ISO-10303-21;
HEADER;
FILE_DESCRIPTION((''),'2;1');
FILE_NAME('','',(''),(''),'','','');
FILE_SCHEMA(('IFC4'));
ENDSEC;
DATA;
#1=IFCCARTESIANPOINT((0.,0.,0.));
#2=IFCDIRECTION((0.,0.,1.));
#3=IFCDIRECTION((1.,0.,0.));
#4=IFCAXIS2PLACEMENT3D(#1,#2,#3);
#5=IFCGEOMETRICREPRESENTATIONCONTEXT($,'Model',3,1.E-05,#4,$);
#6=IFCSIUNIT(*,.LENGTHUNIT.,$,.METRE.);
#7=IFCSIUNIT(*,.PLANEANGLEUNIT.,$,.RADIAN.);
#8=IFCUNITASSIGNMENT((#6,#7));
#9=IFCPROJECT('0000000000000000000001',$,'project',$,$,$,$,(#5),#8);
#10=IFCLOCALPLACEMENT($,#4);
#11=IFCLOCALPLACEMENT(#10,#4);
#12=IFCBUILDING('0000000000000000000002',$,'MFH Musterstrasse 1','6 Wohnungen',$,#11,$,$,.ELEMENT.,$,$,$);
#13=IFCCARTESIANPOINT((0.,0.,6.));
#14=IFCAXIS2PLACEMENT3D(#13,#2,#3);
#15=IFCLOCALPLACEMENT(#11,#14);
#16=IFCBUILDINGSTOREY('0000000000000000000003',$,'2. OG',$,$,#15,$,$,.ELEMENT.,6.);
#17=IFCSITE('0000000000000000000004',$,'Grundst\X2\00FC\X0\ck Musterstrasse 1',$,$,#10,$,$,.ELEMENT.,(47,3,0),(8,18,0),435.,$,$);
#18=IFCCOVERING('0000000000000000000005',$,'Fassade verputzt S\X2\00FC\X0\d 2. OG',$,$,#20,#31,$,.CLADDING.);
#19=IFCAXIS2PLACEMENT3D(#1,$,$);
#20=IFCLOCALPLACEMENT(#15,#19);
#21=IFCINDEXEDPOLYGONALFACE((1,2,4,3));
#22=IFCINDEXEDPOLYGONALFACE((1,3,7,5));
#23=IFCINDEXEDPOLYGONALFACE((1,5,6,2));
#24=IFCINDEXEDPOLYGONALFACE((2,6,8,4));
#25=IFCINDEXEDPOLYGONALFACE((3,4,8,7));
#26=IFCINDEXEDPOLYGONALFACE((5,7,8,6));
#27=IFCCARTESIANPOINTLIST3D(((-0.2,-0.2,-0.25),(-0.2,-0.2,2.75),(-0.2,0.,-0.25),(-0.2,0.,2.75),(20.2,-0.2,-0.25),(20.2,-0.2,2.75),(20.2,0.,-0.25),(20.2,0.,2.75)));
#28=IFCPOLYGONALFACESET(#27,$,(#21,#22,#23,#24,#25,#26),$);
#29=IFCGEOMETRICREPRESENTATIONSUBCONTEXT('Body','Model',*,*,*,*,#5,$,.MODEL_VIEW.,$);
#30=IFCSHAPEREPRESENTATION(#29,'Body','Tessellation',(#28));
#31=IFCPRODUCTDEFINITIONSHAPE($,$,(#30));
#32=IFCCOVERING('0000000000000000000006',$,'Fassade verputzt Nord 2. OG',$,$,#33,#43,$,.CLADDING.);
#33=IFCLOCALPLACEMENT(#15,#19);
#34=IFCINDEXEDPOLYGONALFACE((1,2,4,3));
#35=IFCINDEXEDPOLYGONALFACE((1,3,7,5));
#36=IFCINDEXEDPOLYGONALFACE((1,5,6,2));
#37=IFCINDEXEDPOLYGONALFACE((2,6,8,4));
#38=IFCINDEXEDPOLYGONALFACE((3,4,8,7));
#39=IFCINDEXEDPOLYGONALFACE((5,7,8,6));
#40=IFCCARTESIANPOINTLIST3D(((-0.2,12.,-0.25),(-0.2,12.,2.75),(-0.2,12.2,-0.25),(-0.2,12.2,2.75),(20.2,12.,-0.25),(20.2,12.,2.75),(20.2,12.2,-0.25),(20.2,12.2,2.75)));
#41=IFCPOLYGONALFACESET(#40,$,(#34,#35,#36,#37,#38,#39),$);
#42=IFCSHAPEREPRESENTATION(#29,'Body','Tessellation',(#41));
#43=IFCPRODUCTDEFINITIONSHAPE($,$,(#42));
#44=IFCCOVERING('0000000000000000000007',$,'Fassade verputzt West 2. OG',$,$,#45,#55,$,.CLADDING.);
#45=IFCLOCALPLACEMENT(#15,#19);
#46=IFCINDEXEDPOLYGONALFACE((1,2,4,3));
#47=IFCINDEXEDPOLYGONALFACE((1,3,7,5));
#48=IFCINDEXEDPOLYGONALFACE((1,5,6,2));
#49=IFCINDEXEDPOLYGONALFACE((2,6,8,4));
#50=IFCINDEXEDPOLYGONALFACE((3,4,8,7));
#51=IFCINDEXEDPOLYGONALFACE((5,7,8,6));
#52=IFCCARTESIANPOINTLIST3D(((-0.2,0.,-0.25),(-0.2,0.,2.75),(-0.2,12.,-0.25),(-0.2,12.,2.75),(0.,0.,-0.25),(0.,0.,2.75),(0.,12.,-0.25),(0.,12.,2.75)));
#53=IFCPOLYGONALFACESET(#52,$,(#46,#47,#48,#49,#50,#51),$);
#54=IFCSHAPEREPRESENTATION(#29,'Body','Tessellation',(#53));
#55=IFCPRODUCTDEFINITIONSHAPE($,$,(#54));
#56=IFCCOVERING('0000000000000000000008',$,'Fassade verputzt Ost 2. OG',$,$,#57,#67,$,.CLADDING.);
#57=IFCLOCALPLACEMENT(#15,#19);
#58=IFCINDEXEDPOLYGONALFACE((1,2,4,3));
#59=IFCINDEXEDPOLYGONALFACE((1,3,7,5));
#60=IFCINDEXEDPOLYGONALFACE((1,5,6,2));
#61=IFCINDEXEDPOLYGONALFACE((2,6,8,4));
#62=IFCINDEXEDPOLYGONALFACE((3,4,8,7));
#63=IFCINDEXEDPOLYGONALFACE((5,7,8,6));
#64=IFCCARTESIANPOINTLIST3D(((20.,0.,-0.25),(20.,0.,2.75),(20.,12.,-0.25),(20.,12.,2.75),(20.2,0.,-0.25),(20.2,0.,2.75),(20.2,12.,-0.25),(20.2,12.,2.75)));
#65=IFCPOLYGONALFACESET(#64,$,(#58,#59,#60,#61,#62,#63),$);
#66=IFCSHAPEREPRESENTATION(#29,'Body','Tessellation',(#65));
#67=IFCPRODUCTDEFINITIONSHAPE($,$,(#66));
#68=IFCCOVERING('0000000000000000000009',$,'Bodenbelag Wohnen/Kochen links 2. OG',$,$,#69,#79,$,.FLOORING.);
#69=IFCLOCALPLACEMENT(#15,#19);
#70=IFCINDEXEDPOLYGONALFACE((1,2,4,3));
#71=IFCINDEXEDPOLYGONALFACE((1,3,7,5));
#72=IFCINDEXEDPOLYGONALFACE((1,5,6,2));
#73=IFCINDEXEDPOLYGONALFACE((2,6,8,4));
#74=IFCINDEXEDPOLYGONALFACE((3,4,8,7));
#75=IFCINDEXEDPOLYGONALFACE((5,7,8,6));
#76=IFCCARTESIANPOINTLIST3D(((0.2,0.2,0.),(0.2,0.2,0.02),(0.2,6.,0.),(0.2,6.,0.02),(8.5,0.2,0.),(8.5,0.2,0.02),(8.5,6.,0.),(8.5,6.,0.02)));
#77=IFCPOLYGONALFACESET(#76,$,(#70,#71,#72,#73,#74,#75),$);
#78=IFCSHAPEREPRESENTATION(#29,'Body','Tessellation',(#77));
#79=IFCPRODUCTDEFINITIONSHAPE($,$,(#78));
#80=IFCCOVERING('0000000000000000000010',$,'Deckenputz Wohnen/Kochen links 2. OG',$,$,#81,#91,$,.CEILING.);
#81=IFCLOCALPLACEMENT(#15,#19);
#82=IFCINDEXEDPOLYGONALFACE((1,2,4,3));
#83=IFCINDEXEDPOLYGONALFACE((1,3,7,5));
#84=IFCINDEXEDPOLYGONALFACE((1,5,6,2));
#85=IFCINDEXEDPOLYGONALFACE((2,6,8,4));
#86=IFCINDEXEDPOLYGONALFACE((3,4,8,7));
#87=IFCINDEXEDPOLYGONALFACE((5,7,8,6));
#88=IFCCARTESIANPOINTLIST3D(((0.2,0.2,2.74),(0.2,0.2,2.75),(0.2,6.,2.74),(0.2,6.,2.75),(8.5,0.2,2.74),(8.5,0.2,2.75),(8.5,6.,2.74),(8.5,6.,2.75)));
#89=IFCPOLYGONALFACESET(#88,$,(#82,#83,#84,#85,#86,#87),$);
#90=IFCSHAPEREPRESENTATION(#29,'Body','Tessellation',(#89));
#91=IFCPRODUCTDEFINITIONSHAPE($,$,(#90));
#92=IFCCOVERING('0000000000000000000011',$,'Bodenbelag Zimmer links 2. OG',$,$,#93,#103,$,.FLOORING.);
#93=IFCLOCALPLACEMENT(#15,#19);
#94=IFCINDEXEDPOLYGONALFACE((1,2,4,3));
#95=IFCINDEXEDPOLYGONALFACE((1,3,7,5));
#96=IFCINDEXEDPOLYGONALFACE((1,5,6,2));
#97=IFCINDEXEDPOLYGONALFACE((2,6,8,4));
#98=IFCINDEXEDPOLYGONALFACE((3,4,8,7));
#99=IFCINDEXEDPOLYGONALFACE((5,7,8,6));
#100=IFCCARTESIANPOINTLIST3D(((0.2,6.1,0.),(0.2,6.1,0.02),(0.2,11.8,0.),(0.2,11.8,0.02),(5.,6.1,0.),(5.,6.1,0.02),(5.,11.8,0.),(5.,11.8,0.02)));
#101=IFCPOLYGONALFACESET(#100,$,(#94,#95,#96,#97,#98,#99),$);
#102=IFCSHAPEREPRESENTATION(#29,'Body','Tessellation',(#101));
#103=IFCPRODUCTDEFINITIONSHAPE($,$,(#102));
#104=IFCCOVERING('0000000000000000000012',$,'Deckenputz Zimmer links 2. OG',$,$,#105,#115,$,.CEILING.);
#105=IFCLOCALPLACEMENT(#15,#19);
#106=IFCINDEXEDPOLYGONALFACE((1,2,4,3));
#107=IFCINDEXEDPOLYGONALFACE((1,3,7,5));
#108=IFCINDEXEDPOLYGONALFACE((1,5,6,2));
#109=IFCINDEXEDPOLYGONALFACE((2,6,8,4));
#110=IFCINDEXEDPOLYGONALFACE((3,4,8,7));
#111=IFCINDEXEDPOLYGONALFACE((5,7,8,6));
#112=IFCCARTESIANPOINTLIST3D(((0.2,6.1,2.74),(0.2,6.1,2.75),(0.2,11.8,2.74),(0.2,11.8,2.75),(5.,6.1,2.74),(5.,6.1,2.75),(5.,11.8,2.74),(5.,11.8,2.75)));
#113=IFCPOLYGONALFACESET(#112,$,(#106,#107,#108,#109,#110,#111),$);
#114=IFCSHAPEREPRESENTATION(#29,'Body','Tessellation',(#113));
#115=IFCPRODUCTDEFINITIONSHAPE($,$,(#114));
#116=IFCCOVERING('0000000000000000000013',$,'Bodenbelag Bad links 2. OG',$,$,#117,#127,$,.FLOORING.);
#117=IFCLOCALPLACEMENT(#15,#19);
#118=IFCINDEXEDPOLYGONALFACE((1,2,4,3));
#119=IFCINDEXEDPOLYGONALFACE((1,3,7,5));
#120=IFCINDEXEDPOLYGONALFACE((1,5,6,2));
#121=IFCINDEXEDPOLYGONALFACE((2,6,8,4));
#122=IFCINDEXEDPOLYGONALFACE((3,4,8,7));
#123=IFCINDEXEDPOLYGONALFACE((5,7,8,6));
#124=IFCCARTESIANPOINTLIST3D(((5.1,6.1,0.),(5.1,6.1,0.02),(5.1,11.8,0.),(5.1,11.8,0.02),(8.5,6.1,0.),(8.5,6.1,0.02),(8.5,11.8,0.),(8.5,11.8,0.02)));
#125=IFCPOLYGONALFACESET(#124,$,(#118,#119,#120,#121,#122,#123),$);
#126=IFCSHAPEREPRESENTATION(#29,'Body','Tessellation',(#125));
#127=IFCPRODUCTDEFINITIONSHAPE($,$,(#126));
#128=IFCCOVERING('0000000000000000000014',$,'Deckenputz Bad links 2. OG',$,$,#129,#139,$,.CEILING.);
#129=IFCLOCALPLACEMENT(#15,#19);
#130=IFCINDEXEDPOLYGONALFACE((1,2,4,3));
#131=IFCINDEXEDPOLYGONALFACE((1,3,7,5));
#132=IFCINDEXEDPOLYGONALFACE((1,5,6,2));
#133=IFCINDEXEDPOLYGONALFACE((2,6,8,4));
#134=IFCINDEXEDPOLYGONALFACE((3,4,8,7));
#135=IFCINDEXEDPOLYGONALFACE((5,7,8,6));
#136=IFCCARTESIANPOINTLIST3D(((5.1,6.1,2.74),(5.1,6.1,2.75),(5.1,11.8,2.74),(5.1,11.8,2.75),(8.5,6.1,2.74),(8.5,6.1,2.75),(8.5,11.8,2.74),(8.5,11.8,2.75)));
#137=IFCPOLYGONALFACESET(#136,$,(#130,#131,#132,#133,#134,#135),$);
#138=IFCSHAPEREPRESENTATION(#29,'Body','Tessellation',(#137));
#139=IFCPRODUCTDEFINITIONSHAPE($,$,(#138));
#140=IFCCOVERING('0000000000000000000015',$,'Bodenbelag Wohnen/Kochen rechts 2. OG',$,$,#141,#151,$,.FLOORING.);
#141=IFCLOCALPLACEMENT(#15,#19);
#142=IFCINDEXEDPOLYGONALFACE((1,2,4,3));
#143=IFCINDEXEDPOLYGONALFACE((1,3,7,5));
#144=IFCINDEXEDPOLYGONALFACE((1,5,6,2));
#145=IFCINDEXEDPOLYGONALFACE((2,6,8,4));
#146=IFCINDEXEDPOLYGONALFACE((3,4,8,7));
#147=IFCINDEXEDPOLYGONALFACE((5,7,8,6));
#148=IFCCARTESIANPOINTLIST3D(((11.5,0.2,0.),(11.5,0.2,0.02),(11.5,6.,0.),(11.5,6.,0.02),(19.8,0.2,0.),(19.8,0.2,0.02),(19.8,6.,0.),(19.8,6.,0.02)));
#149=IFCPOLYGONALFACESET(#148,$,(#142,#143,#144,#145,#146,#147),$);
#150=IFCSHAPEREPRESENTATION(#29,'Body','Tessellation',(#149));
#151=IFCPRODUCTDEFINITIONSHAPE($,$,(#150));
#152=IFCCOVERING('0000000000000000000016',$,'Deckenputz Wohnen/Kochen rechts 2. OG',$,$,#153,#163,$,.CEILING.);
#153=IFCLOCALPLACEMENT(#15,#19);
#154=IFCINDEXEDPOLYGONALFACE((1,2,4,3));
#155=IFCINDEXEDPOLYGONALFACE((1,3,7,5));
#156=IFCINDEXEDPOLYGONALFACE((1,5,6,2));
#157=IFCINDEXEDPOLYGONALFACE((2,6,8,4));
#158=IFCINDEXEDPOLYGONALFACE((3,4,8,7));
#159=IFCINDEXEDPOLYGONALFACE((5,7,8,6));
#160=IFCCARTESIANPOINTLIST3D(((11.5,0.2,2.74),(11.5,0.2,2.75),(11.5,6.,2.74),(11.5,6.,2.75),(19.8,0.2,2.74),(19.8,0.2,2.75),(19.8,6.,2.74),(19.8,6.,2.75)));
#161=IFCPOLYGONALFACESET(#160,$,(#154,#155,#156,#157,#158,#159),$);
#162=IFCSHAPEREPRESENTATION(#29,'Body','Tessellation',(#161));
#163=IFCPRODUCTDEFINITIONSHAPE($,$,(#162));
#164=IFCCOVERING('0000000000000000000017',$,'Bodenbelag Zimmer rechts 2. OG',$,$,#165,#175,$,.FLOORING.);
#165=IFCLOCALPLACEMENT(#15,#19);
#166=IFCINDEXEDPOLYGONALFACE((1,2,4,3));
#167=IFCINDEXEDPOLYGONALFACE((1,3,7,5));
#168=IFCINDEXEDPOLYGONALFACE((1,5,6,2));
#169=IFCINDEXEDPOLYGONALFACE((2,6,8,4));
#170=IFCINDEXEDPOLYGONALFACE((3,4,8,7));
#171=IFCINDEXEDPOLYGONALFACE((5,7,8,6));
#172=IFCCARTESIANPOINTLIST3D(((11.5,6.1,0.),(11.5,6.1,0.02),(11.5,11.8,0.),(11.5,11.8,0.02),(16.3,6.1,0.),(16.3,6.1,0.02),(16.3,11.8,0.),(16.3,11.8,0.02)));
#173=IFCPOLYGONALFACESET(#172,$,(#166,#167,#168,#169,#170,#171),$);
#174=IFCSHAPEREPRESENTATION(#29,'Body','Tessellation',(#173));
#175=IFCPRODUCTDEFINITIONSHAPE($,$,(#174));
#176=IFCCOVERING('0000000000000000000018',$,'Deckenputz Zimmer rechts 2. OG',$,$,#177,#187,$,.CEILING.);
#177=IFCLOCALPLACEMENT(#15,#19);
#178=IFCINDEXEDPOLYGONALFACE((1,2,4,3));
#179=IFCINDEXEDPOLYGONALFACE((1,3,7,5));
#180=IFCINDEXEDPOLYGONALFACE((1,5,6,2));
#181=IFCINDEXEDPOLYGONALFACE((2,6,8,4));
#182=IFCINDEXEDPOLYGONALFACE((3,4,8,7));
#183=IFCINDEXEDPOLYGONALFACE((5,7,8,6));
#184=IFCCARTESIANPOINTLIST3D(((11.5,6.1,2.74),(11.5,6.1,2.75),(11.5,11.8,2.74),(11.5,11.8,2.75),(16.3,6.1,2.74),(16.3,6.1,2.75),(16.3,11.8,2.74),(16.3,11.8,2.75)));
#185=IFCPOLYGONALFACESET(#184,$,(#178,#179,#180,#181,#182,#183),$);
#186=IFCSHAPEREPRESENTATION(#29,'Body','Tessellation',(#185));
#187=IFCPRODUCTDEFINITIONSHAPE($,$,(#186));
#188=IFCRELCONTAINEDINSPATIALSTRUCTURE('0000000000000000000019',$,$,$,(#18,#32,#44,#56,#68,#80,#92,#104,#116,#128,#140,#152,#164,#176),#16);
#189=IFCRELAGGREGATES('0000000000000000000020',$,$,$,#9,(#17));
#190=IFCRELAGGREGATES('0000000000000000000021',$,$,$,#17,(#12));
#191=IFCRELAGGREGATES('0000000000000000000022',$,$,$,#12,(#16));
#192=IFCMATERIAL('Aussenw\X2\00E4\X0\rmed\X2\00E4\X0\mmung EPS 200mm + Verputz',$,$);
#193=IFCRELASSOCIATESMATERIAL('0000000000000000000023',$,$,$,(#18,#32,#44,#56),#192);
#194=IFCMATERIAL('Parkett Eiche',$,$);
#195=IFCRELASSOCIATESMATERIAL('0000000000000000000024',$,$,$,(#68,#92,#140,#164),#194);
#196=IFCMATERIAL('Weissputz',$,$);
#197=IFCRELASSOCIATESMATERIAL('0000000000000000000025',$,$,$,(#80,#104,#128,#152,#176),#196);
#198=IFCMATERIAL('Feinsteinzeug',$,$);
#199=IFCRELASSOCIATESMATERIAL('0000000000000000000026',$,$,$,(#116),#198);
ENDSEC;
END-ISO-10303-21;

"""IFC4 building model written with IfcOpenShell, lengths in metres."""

from ifc_helpers import new_model, si_unit, frame, frame_2d, origin_with_axes, place, context, subcontext, project, spatial, rectangle, extrude, material, element, save


model = new_model("IFC4")

# Units and contexts
model_context = context("Model", 3, precision=1e-05, world=origin_with_axes())
body_context = subcontext(model_context, "Body", "Model", "MODEL_VIEW")
ifc_project = project(units=[si_unit("LENGTHUNIT", "METRE"), si_unit("PLANEANGLEUNIT", "RADIAN")], contexts=[model_context])

# Site, building, storey
site_placement = place(None, origin_with_axes())
site = spatial("IfcSite", under=ifc_project, at=site_placement, Name="Grundstück Musterstrasse 1", CompositionType="ELEMENT", RefLatitude=(47, 3, 0), RefLongitude=(8, 18, 0), RefElevation=435.0)
building_placement = place(site_placement, origin_with_axes())
building = spatial("IfcBuilding", under=site, at=building_placement, Name="MFH Musterstrasse 1", Description="6 Wohnungen", CompositionType="ELEMENT")
storey_placement = place(building_placement, frame((0.0, 0.0, 6.0), z_axis=(0.0, 0.0, 1.0), x_axis=(1.0, 0.0, 0.0)))
storey = spatial("IfcBuildingStorey", under=building, at=storey_placement, Name="2. OG", CompositionType="ELEMENT", Elevation=6.0)

# Coverings
ifc_material_1 = material(Name="Aussenwärmedämmung EPS 200mm + Verputz")
covering_1_placement = place(storey_placement, origin_with_axes())
element("IfcCovering", 1, at=covering_1_placement, inside=storey, material=ifc_material_1, Name="Fassade verputzt Süd 2. OG", PredefinedType="CLADDING", context=body_context, shape_type="SweptSolid", body=[
    extrude(rectangle(XDim=20.4, YDim=0.2, at=frame_2d((10.2, 0.1), x_axis=(1.0, 0.0))), frame((-0.2, -0.2, -0.25), z_axis=(0.0, 0.0, 1.0), x_axis=(1.0, 0.0, 0.0)), (0.0, 0.0, 1.0), 3.0),
])
covering_2_placement = place(storey_placement, origin_with_axes())
element("IfcCovering", 2, at=covering_2_placement, inside=storey, material=ifc_material_1, Name="Fassade verputzt Nord 2. OG", PredefinedType="CLADDING", context=body_context, shape_type="SweptSolid", body=[
    extrude(rectangle(XDim=20.4, YDim=0.2, at=frame_2d((10.2, 0.1), x_axis=(1.0, 0.0))), frame((-0.2, 12.0, -0.25), z_axis=(0.0, 0.0, 1.0), x_axis=(1.0, 0.0, 0.0)), (0.0, 0.0, 1.0), 3.0),
])
covering_3_placement = place(storey_placement, origin_with_axes())
element("IfcCovering", 3, at=covering_3_placement, inside=storey, material=ifc_material_1, Name="Fassade verputzt West 2. OG", PredefinedType="CLADDING", context=body_context, shape_type="SweptSolid", body=[
    extrude(rectangle(XDim=0.2, YDim=12.0, at=frame_2d((0.1, 6.0), x_axis=(1.0, 0.0))), frame((-0.2, 0.0, -0.25), z_axis=(0.0, 0.0, 1.0), x_axis=(1.0, 0.0, 0.0)), (0.0, 0.0, 1.0), 3.0),
])
covering_4_placement = place(storey_placement, origin_with_axes())
element("IfcCovering", 4, at=covering_4_placement, inside=storey, material=ifc_material_1, Name="Fassade verputzt Ost 2. OG", PredefinedType="CLADDING", context=body_context, shape_type="SweptSolid", body=[
    extrude(rectangle(XDim=0.2, YDim=12.0, at=frame_2d((0.1, 6.0), x_axis=(1.0, 0.0))), frame((20.0, 0.0, -0.25), z_axis=(0.0, 0.0, 1.0), x_axis=(1.0, 0.0, 0.0)), (0.0, 0.0, 1.0), 3.0),
])
ifc_material_2 = material(Name="Parkett Eiche")
covering_5_placement = place(storey_placement, origin_with_axes())
element("IfcCovering", 5, at=covering_5_placement, inside=storey, material=ifc_material_2, Name="Bodenbelag Wohnen/Kochen links 2. OG", PredefinedType="FLOORING", context=body_context, shape_type="SweptSolid", body=[
    extrude(rectangle(XDim=8.3, YDim=5.8, at=frame_2d((4.15, 2.9), x_axis=(1.0, 0.0))), frame((0.2, 0.2, 0.0), z_axis=(0.0, 0.0, 1.0), x_axis=(1.0, 0.0, 0.0)), (0.0, 0.0, 1.0), 0.02),
])
ifc_material_3 = material(Name="Weissputz")
covering_6_placement = place(storey_placement, origin_with_axes())
element("IfcCovering", 6, at=covering_6_placement, inside=storey, material=ifc_material_3, Name="Deckenputz Wohnen/Kochen links 2. OG", PredefinedType="CEILING", context=body_context, shape_type="SweptSolid", body=[
    extrude(rectangle(XDim=8.3, YDim=5.8, at=frame_2d((4.15, 2.9), x_axis=(1.0, 0.0))), frame((0.2, 0.2, 2.74), z_axis=(0.0, 0.0, 1.0), x_axis=(1.0, 0.0, 0.0)), (0.0, 0.0, 1.0), 0.01),
])
covering_7_placement = place(storey_placement, origin_with_axes())
element("IfcCovering", 7, at=covering_7_placement, inside=storey, material=ifc_material_2, Name="Bodenbelag Zimmer links 2. OG", PredefinedType="FLOORING", context=body_context, shape_type="SweptSolid", body=[
    extrude(rectangle(XDim=4.8, YDim=5.7, at=frame_2d((2.4, 2.85), x_axis=(1.0, 0.0))), frame((0.2, 6.1, 0.0), z_axis=(0.0, 0.0, 1.0), x_axis=(1.0, 0.0, 0.0)), (0.0, 0.0, 1.0), 0.02),
])
covering_8_placement = place(storey_placement, origin_with_axes())
element("IfcCovering", 8, at=covering_8_placement, inside=storey, material=ifc_material_3, Name="Deckenputz Zimmer links 2. OG", PredefinedType="CEILING", context=body_context, shape_type="SweptSolid", body=[
    extrude(rectangle(XDim=4.8, YDim=5.7, at=frame_2d((2.4, 2.85), x_axis=(1.0, 0.0))), frame((0.2, 6.1, 2.74), z_axis=(0.0, 0.0, 1.0), x_axis=(1.0, 0.0, 0.0)), (0.0, 0.0, 1.0), 0.01),
])
ifc_material_4 = material(Name="Feinsteinzeug")
covering_9_placement = place(storey_placement, origin_with_axes())
element("IfcCovering", 9, at=covering_9_placement, inside=storey, material=ifc_material_4, Name="Bodenbelag Bad links 2. OG", PredefinedType="FLOORING", context=body_context, shape_type="SweptSolid", body=[
    extrude(rectangle(XDim=3.4, YDim=5.7, at=frame_2d((1.7, 2.85), x_axis=(1.0, 0.0))), frame((5.1, 6.1, 0.0), z_axis=(0.0, 0.0, 1.0), x_axis=(1.0, 0.0, 0.0)), (0.0, 0.0, 1.0), 0.02),
])
covering_10_placement = place(storey_placement, origin_with_axes())
element("IfcCovering", 10, at=covering_10_placement, inside=storey, material=ifc_material_3, Name="Deckenputz Bad links 2. OG", PredefinedType="CEILING", context=body_context, shape_type="SweptSolid", body=[
    extrude(rectangle(XDim=3.4, YDim=5.7, at=frame_2d((1.7, 2.85), x_axis=(1.0, 0.0))), frame((5.1, 6.1, 2.74), z_axis=(0.0, 0.0, 1.0), x_axis=(1.0, 0.0, 0.0)), (0.0, 0.0, 1.0), 0.01),
])
covering_11_placement = place(storey_placement, origin_with_axes())
element("IfcCovering", 11, at=covering_11_placement, inside=storey, material=ifc_material_2, Name="Bodenbelag Wohnen/Kochen rechts 2. OG", PredefinedType="FLOORING", context=body_context, shape_type="SweptSolid", body=[
    extrude(rectangle(XDim=8.3, YDim=5.8, at=frame_2d((4.15, 2.9), x_axis=(1.0, 0.0))), frame((11.5, 0.2, 0.0), z_axis=(0.0, 0.0, 1.0), x_axis=(1.0, 0.0, 0.0)), (0.0, 0.0, 1.0), 0.02),
])
covering_12_placement = place(storey_placement, origin_with_axes())
element("IfcCovering", 12, at=covering_12_placement, inside=storey, material=ifc_material_3, Name="Deckenputz Wohnen/Kochen rechts 2. OG", PredefinedType="CEILING", context=body_context, shape_type="SweptSolid", body=[
    extrude(rectangle(XDim=8.3, YDim=5.8, at=frame_2d((4.15, 2.9), x_axis=(1.0, 0.0))), frame((11.5, 0.2, 2.74), z_axis=(0.0, 0.0, 1.0), x_axis=(1.0, 0.0, 0.0)), (0.0, 0.0, 1.0), 0.01),
])
covering_13_placement = place(storey_placement, origin_with_axes())
element("IfcCovering", 13, at=covering_13_placement, inside=storey, material=ifc_material_2, Name="Bodenbelag Zimmer rechts 2. OG", PredefinedType="FLOORING", context=body_context, shape_type="SweptSolid", body=[
    extrude(rectangle(XDim=4.8, YDim=5.7, at=frame_2d((2.4, 2.85), x_axis=(1.0, 0.0))), frame((11.5, 6.1, 0.0), z_axis=(0.0, 0.0, 1.0), x_axis=(1.0, 0.0, 0.0)), (0.0, 0.0, 1.0), 0.02),
])
covering_14_placement = place(storey_placement, origin_with_axes())
element("IfcCovering", 14, at=covering_14_placement, inside=storey, material=ifc_material_3, Name="Deckenputz Zimmer rechts 2. OG", PredefinedType="CEILING", context=body_context, shape_type="SweptSolid", body=[
    extrude(rectangle(XDim=4.8, YDim=5.7, at=frame_2d((2.4, 2.85), x_axis=(1.0, 0.0))), frame((11.5, 6.1, 2.74), z_axis=(0.0, 0.0, 1.0), x_axis=(1.0, 0.0, 0.0)), (0.0, 0.0, 1.0), 0.01),
])

save(model, "model.ifc")
